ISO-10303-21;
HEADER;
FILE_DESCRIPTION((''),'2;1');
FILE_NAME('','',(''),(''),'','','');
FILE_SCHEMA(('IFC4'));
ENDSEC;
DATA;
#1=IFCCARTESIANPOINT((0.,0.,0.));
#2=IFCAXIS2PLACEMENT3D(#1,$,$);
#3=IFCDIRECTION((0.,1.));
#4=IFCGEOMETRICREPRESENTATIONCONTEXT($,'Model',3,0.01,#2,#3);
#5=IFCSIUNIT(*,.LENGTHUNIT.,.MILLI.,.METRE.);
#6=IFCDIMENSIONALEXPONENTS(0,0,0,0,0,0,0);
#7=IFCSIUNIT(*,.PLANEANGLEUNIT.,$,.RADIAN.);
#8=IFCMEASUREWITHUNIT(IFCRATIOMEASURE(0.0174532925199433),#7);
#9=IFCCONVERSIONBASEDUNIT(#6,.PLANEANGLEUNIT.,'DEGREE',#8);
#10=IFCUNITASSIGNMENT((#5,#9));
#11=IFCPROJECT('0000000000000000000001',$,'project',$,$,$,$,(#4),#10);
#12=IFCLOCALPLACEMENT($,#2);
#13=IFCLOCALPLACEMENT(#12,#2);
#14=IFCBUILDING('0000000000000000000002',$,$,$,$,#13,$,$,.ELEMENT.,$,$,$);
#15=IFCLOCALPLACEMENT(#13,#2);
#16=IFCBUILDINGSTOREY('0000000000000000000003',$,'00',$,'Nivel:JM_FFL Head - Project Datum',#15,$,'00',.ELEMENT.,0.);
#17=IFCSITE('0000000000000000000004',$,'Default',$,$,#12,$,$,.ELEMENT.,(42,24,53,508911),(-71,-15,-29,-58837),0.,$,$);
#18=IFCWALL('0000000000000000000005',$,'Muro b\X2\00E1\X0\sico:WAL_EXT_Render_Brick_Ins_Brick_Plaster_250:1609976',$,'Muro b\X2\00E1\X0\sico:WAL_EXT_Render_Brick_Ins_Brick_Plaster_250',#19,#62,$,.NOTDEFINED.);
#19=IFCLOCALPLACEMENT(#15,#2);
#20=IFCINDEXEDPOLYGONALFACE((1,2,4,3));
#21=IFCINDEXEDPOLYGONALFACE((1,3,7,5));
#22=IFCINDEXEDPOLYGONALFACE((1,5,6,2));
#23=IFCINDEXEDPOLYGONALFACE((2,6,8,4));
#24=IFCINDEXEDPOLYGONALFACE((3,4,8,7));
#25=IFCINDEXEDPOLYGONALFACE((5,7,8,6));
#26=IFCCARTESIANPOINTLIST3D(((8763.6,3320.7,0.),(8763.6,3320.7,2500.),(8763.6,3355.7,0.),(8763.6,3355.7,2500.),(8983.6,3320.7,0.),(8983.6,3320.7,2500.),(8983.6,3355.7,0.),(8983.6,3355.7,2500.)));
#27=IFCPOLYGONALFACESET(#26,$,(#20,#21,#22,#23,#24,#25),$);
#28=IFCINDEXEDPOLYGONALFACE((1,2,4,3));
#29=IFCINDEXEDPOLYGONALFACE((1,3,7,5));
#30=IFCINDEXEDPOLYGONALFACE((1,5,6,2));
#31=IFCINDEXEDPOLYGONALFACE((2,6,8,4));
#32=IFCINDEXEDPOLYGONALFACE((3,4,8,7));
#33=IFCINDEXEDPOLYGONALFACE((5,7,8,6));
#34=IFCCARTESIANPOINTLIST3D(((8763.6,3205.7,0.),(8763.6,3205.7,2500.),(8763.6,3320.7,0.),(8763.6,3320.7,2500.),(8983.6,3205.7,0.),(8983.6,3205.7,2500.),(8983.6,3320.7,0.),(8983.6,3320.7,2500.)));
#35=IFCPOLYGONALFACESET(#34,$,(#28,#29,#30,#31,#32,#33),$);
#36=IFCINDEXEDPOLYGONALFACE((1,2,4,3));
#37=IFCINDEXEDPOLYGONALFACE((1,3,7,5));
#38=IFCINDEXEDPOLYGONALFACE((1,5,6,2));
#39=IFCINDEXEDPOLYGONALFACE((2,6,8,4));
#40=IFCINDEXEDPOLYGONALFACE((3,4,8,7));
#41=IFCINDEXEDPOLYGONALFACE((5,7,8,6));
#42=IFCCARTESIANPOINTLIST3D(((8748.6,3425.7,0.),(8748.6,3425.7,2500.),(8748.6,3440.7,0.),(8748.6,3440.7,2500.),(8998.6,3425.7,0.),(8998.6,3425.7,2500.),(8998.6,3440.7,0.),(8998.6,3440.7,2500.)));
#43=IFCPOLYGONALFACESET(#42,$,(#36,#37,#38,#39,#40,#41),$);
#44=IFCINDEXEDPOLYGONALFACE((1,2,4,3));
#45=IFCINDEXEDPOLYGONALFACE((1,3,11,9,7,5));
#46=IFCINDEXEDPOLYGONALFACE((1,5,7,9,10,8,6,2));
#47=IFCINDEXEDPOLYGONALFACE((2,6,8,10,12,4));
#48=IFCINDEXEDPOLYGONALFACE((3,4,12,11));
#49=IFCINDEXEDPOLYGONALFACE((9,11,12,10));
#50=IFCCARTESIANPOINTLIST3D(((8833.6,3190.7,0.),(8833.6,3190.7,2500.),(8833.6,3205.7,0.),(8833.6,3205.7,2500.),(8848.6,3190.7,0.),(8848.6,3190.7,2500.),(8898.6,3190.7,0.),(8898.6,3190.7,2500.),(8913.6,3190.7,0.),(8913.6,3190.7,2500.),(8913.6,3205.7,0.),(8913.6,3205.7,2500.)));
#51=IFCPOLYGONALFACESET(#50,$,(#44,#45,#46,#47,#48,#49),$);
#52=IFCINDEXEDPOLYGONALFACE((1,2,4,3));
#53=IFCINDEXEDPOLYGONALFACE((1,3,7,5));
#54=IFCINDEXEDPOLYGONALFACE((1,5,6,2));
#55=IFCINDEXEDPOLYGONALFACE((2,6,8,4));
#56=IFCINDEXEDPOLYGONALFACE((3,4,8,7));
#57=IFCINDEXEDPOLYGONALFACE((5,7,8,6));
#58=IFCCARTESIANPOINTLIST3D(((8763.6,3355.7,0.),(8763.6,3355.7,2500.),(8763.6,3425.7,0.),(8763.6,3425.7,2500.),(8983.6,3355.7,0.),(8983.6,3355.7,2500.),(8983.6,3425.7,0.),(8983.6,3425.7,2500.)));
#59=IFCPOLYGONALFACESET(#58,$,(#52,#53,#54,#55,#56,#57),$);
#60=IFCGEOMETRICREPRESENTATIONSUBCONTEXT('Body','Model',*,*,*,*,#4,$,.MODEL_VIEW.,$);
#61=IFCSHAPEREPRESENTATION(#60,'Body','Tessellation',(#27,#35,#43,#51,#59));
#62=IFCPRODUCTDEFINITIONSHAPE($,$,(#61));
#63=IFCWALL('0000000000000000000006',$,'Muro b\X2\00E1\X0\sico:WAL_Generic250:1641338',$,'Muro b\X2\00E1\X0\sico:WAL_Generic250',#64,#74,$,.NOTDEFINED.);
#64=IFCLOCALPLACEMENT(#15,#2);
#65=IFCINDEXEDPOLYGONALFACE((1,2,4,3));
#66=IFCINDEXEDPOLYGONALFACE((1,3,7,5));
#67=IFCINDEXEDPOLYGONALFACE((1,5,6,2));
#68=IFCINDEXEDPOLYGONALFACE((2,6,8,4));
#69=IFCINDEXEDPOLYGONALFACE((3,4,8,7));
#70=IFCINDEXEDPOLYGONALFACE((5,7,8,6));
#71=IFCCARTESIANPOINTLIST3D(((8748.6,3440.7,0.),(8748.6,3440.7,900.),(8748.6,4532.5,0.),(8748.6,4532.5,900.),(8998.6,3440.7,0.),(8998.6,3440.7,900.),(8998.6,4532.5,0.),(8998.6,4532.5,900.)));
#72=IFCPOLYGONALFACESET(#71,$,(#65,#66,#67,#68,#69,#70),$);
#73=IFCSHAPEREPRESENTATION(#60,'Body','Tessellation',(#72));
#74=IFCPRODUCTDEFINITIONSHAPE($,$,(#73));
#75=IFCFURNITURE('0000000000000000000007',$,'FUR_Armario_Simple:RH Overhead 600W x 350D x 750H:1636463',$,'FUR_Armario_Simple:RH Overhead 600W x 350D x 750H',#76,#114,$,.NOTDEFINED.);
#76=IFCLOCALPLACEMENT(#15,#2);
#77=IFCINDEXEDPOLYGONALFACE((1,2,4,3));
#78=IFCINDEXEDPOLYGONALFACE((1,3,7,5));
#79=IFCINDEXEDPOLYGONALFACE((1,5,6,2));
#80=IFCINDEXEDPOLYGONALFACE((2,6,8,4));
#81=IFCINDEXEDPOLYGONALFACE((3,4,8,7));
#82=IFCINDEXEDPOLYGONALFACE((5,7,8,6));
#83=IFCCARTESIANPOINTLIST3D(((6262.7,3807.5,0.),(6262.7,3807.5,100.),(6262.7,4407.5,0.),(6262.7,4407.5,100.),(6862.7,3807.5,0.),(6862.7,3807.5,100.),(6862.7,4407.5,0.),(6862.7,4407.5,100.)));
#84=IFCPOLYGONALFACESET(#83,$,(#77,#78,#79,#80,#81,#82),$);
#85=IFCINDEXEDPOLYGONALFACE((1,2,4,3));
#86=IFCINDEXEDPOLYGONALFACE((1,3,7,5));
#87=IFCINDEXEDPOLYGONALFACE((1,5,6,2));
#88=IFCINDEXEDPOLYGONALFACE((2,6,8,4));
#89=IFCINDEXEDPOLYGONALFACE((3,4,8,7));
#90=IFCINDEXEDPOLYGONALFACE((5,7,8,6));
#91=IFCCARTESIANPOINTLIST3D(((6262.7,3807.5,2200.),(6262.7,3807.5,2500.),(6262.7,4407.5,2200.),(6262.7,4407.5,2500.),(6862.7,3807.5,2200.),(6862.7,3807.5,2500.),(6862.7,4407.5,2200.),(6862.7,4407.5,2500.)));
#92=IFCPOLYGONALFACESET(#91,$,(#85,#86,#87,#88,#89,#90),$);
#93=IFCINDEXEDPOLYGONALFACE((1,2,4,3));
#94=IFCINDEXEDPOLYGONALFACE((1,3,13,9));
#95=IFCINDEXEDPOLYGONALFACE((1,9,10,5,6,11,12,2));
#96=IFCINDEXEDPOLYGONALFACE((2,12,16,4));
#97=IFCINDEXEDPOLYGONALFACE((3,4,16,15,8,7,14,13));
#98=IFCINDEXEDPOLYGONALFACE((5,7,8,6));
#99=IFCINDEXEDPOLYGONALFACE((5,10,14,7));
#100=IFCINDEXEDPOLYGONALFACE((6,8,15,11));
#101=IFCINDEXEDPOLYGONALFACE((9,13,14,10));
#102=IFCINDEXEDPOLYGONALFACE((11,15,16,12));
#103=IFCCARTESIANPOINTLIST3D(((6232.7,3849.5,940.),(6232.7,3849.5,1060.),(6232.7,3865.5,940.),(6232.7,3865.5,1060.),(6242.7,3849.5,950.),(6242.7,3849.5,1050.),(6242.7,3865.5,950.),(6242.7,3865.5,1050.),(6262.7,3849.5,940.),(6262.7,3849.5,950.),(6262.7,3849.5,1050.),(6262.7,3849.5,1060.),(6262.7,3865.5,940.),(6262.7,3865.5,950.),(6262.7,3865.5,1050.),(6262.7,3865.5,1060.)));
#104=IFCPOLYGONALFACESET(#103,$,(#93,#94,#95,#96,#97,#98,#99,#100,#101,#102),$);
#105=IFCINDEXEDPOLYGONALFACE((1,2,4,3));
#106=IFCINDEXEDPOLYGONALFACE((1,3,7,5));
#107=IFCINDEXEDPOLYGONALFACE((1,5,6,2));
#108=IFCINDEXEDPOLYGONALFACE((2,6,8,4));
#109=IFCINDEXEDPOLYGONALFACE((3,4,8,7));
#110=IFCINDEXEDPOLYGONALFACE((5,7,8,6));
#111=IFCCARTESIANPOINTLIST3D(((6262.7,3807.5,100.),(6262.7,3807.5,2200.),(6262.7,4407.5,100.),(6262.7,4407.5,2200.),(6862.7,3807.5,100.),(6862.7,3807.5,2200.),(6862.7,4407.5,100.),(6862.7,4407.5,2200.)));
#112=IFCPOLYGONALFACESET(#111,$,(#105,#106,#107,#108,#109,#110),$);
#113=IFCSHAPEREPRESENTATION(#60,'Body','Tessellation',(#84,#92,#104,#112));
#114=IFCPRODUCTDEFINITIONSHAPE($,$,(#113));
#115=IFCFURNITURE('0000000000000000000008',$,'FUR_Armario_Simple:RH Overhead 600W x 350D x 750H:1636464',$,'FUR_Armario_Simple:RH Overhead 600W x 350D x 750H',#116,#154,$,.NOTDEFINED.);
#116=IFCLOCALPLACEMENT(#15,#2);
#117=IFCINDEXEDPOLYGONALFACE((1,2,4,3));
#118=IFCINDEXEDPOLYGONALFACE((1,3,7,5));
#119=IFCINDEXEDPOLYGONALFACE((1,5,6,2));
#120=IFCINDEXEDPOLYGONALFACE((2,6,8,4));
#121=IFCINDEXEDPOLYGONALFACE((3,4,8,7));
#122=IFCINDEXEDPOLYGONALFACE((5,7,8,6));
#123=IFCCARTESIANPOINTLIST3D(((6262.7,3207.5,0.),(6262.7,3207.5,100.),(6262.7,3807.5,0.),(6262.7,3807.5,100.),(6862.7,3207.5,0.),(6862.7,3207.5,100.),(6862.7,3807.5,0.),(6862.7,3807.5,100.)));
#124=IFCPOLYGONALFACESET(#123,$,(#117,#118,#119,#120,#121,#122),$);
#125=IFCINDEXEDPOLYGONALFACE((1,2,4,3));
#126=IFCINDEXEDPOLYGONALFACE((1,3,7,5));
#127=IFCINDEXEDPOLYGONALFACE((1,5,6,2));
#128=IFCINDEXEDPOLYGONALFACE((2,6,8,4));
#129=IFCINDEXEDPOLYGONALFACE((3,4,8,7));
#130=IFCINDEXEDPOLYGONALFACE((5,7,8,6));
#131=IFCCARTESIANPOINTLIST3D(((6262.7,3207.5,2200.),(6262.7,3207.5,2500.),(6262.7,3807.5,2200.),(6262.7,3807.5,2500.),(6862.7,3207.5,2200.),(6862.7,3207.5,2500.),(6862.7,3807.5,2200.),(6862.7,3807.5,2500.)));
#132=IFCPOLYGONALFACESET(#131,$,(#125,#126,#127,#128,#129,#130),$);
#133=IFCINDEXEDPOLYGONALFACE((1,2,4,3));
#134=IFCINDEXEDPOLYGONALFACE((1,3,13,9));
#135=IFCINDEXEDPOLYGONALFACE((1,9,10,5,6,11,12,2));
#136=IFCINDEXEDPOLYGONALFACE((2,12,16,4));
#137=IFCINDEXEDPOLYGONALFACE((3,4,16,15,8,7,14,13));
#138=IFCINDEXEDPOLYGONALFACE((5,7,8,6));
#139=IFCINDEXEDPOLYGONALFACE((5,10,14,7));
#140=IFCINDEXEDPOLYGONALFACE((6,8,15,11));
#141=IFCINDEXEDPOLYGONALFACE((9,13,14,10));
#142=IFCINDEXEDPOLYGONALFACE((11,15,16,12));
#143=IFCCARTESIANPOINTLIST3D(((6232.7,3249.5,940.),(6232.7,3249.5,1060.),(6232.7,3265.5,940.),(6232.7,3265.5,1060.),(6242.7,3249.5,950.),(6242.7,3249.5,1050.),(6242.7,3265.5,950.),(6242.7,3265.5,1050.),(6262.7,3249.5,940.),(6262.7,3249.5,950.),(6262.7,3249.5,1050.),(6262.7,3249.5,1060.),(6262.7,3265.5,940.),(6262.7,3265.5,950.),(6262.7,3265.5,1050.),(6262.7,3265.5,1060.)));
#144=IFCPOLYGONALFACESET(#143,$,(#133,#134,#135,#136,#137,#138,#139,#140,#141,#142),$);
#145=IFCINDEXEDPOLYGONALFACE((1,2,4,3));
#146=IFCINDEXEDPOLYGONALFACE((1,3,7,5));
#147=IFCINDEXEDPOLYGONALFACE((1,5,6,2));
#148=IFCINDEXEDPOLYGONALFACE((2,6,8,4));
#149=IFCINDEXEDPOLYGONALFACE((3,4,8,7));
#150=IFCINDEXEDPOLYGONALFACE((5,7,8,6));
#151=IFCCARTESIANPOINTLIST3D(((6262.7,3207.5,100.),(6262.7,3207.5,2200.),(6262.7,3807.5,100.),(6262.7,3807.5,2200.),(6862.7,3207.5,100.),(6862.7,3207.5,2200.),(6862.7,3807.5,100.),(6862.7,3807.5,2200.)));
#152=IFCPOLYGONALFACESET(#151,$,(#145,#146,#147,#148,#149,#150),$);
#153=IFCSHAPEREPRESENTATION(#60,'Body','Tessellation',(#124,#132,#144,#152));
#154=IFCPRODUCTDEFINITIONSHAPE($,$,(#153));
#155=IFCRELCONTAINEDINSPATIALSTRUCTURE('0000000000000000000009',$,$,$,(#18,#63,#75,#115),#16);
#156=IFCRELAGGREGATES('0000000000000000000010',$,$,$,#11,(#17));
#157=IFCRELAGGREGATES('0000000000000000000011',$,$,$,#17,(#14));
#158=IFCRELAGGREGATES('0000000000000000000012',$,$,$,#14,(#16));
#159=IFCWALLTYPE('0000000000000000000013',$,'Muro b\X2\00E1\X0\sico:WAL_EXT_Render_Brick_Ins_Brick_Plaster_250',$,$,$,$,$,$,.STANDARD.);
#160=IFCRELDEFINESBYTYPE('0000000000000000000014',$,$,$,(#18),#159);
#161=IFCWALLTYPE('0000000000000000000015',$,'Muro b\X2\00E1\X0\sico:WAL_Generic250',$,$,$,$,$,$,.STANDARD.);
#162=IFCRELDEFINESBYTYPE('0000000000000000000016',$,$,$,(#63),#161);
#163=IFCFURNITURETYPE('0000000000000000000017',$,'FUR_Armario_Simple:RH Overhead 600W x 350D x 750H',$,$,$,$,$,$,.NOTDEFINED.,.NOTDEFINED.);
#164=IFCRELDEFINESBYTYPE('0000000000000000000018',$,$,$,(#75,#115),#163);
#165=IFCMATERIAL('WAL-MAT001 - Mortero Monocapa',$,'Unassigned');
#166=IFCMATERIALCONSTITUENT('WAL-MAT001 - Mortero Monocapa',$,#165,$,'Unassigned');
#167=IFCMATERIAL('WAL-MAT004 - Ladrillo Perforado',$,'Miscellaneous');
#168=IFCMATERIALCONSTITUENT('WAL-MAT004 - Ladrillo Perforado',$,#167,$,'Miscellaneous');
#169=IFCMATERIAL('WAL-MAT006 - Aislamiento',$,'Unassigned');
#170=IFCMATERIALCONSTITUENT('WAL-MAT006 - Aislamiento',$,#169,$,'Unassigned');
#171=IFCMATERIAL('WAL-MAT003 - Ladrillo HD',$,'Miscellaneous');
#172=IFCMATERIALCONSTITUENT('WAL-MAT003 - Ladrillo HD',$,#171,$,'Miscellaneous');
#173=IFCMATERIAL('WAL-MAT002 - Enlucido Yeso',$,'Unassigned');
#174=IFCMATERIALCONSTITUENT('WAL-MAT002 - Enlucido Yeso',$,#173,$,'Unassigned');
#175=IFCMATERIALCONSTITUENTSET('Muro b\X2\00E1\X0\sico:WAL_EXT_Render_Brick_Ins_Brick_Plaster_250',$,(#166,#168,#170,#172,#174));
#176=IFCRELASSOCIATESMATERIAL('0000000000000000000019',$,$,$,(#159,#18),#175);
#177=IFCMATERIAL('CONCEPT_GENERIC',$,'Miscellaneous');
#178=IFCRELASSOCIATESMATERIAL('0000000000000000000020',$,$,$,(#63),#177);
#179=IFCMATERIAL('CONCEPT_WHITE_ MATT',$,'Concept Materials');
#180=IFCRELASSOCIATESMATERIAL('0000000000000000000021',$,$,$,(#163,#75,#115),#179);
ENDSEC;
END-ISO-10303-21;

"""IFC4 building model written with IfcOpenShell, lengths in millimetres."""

from ifc_helpers import new_model, entity, si_unit, converted_unit, direction, frame, origin, place, context, subcontext, project, spatial, indexed_curve, outline, extrude, source, transform, mapped, material, constituent, constituent_set, type_object, type_shapes, element, save


model = new_model("IFC4")

# Units and contexts
model_context = context("Model", 3, precision=0.01, world=origin(), true_north=direction((0.0, 1.0)))
body_context = subcontext(model_context, "Body", "Model", "MODEL_VIEW")
ifc_project = project(units=[si_unit("LENGTHUNIT", "METRE", prefix="MILLI"), converted_unit("PLANEANGLEUNIT", "DEGREE", entity("IfcRatioMeasure", 0.0174532925199433), si_unit("PLANEANGLEUNIT", "RADIAN"), dimensions=[0, 0, 0, 0, 0, 0, 0])], contexts=[model_context])

# Site, building, storey
site_placement = place(None, origin())
site = spatial("IfcSite", under=ifc_project, at=site_placement, Name="Default", CompositionType="ELEMENT", RefLatitude=(42, 24, 53, 508911), RefLongitude=(-71, -15, -29, -58837), RefElevation=0.0)
building_placement = place(site_placement, origin())
building = spatial("IfcBuilding", under=site, at=building_placement, CompositionType="ELEMENT")
storey_placement = place(building_placement, origin())
storey = spatial("IfcBuildingStorey", under=building, at=storey_placement, Name="00", ObjectType="Nivel:JM_FFL Head - Project Datum", LongName="00", CompositionType="ELEMENT", Elevation=0.0)

# Shared definitions
ifc_material_1 = material(Name="CONCEPT_WHITE_ MATT", Category="Concept Materials")

# Walls
ifc_material_2 = material(Name="WAL-MAT001 - Mortero Monocapa", Category="Unassigned")
ifc_constituent_1 = constituent(ifc_material_2, Name="WAL-MAT001 - Mortero Monocapa", Category="Unassigned")
ifc_material_3 = material(Name="WAL-MAT004 - Ladrillo Perforado", Category="Miscellaneous")
ifc_constituent_2 = constituent(ifc_material_3, Name="WAL-MAT004 - Ladrillo Perforado", Category="Miscellaneous")
ifc_material_4 = material(Name="WAL-MAT006 - Aislamiento", Category="Unassigned")
ifc_constituent_3 = constituent(ifc_material_4, Name="WAL-MAT006 - Aislamiento", Category="Unassigned")
ifc_material_5 = material(Name="WAL-MAT003 - Ladrillo HD", Category="Miscellaneous")
ifc_constituent_4 = constituent(ifc_material_5, Name="WAL-MAT003 - Ladrillo HD", Category="Miscellaneous")
ifc_material_6 = material(Name="WAL-MAT002 - Enlucido Yeso", Category="Unassigned")
ifc_constituent_5 = constituent(ifc_material_6, Name="WAL-MAT002 - Enlucido Yeso", Category="Unassigned")
ifc_constituent_set_1 = constituent_set(constituents=[ifc_constituent_1, ifc_constituent_2, ifc_constituent_3, ifc_constituent_4, ifc_constituent_5], Name="Muro básico:WAL_EXT_Render_Brick_Ins_Brick_Plaster_250")
wall_type_1 = type_object("IfcWallType", Name="Muro básico:WAL_EXT_Render_Brick_Ins_Brick_Plaster_250", PredefinedType="STANDARD", material=ifc_constituent_set_1)
wall_1_placement = place(storey_placement, frame((8998.6, 3315.7, 0.0), z_axis=(0.0, 0.0, 1.0), x_axis=(-1.0, 0.0, 0.0)))
element("IfcWall", 1, at=wall_1_placement, inside=storey, type_object=wall_type_1, material=ifc_constituent_set_1, Name="Muro básico:WAL_EXT_Render_Brick_Ins_Brick_Plaster_250:1609976", ObjectType="Muro básico:WAL_EXT_Render_Brick_Ins_Brick_Plaster_250", PredefinedType="NOTDEFINED", context=body_context, shape_type="SweptSolid", body=[
    extrude(outline(indexed_curve([(-110.0, -17.5), (110.0, -17.5), (110.0, 17.5), (-110.0, 17.5), (-110.0, -17.5)], self_intersect=False)), frame((125.0, -22.5, 0.0)), (0.0, 0.0, 1.0), 2500.0),
    extrude(outline(indexed_curve([(-110.0, -57.5), (110.0, -57.5), (110.0, 57.5), (-110.0, 57.5), (-110.0, -57.5)], self_intersect=False)), frame((125.0, 52.5, 0.0)), (0.0, 0.0, 1.0), 2500.0),
    extrude(outline(indexed_curve([(-7.5, -125.0), (7.5, -125.0), (7.5, 125.0), (-7.5, 125.0), (-7.5, -125.0)], self_intersect=False)), frame((125.0, -117.5, 0.0), z_axis=(0.0, 0.0, 1.0), x_axis=(0.0, 1.0, 0.0)), (0.0, 0.0, 1.0), 2500.0),
    extrude(outline(indexed_curve([(-25.0, -5.0), (25.0, -5.0), (40.0, -5.0), (40.0, 10.0), (-40.0, 10.0), (-40.0, -5.0), (-25.0, -5.0)], self_intersect=False)), frame((125.0, 120.0, 0.0), z_axis=(0.0, 0.0, 1.0), x_axis=(-1.0, 0.0, 0.0)), (0.0, 0.0, 1.0), 2500.0),
    extrude(outline(indexed_curve([(-110.0, -35.0), (110.0, -35.0), (110.0, 35.0), (-110.0, 35.0), (-110.0, -35.0)], self_intersect=False)), frame((125.0, -75.0, 0.0)), (0.0, 0.0, 1.0), 2500.0),
])
ifc_material_7 = material(Name="CONCEPT_GENERIC", Category="Miscellaneous")
wall_type_2 = type_object("IfcWallType", Name="Muro básico:WAL_Generic250", PredefinedType="STANDARD")
wall_2_placement = place(storey_placement, frame((8873.6, 3440.7, 0.0), z_axis=(0.0, 0.0, 1.0), x_axis=(0.0, 1.0, 0.0)))
element("IfcWall", 2, at=wall_2_placement, inside=storey, type_object=wall_type_2, material=ifc_material_7, Name="Muro básico:WAL_Generic250:1641338", ObjectType="Muro básico:WAL_Generic250", PredefinedType="NOTDEFINED", context=body_context, shape_type="SweptSolid", body=[
    extrude(outline(indexed_curve([(1091.8, 125.0), (0.0, 125.0), (0.0, -125.0), (1091.8, -125.0), (1091.8, 125.0)], self_intersect=False)), origin(), (0.0, 0.0, 1.0), 900.0),
])

# Furniture
furniture_type_1 = type_object("IfcFurnitureType", Name="FUR_Armario_Simple:RH Overhead 600W x 350D x 750H", AssemblyPlace="NOTDEFINED", PredefinedType="NOTDEFINED", material=ifc_material_1)
shared_shape_1 = source(origin(), body_context, "Body", "SweptSolid", [
    extrude(outline(indexed_curve([(-300.0, -300.0), (300.0, -300.0), (300.0, 300.0), (-300.0, 300.0), (-300.0, -300.0)], self_intersect=False)), frame((300.0, -300.0, 0.0), z_axis=(0.0, 0.0, 1.0), x_axis=(-1.0, 0.0, 0.0)), (0.0, 0.0, 1.0), 100.0),
    extrude(outline(indexed_curve([(-300.0, -300.0), (300.0, -300.0), (300.0, 300.0), (-300.0, 300.0), (-300.0, -300.0)], self_intersect=False)), frame((300.0, -300.0, 2200.0), z_axis=(0.0, 0.0, 1.0), x_axis=(-1.0, 0.0, 0.0)), (0.0, 0.0, 1.0), 300.0),
    extrude(outline(indexed_curve([(-60.0, -17.5), (60.0, -17.5), (60.0, 12.5), (50.0, 12.5), (50.0, -7.5), (-50.0, -7.5), (-50.0, 12.5), (-60.0, 12.5), (-60.0, -17.5)], self_intersect=False)), frame((542.0, -612.5, 1000.0), z_axis=(1.0, 0.0, 0.0), x_axis=(0.0, 0.0, -1.0)), (0.0, 0.0, 1.0), 16.0),
    extrude(outline(indexed_curve([(-300.0, -300.0), (300.0, -300.0), (300.0, 300.0), (-300.0, 300.0), (-300.0, -300.0)], self_intersect=False)), frame((300.0, -300.0, 100.0), z_axis=(0.0, 0.0, 1.0), x_axis=(0.0, 1.0, 0.0)), (0.0, 0.0, 1.0), 2100.0),
])
type_shapes(furniture_type_1, [shared_shape_1])
for number, where, z_axis, x_axis, name in (
    (3, (6862.7, 4407.5, 0.0), (0.0, 0.0, 1.0), (0.0, -1.0, 0.0), "FUR_Armario_Simple:RH Overhead 600W x 350D x 750H:1636463"),
    (4, (6862.7, 3807.5, 0.0), (0.0, 0.0, 1.0), (0.0, -1.0, 0.0), "FUR_Armario_Simple:RH Overhead 600W x 350D x 750H:1636464"),
):
    element("IfcFurniture", number, at=place(storey_placement, frame(where, z_axis=z_axis, x_axis=x_axis)), inside=storey, type_object=furniture_type_1, material=ifc_material_1, Name=name, ObjectType="FUR_Armario_Simple:RH Overhead 600W x 350D x 750H", PredefinedType="NOTDEFINED", context=body_context, shape_type="MappedRepresentation", body=[
        mapped(shared_shape_1, transform((0.0, 0.0, 0.0), scale=1.0)),
    ])

save(model, "model.ifc")
